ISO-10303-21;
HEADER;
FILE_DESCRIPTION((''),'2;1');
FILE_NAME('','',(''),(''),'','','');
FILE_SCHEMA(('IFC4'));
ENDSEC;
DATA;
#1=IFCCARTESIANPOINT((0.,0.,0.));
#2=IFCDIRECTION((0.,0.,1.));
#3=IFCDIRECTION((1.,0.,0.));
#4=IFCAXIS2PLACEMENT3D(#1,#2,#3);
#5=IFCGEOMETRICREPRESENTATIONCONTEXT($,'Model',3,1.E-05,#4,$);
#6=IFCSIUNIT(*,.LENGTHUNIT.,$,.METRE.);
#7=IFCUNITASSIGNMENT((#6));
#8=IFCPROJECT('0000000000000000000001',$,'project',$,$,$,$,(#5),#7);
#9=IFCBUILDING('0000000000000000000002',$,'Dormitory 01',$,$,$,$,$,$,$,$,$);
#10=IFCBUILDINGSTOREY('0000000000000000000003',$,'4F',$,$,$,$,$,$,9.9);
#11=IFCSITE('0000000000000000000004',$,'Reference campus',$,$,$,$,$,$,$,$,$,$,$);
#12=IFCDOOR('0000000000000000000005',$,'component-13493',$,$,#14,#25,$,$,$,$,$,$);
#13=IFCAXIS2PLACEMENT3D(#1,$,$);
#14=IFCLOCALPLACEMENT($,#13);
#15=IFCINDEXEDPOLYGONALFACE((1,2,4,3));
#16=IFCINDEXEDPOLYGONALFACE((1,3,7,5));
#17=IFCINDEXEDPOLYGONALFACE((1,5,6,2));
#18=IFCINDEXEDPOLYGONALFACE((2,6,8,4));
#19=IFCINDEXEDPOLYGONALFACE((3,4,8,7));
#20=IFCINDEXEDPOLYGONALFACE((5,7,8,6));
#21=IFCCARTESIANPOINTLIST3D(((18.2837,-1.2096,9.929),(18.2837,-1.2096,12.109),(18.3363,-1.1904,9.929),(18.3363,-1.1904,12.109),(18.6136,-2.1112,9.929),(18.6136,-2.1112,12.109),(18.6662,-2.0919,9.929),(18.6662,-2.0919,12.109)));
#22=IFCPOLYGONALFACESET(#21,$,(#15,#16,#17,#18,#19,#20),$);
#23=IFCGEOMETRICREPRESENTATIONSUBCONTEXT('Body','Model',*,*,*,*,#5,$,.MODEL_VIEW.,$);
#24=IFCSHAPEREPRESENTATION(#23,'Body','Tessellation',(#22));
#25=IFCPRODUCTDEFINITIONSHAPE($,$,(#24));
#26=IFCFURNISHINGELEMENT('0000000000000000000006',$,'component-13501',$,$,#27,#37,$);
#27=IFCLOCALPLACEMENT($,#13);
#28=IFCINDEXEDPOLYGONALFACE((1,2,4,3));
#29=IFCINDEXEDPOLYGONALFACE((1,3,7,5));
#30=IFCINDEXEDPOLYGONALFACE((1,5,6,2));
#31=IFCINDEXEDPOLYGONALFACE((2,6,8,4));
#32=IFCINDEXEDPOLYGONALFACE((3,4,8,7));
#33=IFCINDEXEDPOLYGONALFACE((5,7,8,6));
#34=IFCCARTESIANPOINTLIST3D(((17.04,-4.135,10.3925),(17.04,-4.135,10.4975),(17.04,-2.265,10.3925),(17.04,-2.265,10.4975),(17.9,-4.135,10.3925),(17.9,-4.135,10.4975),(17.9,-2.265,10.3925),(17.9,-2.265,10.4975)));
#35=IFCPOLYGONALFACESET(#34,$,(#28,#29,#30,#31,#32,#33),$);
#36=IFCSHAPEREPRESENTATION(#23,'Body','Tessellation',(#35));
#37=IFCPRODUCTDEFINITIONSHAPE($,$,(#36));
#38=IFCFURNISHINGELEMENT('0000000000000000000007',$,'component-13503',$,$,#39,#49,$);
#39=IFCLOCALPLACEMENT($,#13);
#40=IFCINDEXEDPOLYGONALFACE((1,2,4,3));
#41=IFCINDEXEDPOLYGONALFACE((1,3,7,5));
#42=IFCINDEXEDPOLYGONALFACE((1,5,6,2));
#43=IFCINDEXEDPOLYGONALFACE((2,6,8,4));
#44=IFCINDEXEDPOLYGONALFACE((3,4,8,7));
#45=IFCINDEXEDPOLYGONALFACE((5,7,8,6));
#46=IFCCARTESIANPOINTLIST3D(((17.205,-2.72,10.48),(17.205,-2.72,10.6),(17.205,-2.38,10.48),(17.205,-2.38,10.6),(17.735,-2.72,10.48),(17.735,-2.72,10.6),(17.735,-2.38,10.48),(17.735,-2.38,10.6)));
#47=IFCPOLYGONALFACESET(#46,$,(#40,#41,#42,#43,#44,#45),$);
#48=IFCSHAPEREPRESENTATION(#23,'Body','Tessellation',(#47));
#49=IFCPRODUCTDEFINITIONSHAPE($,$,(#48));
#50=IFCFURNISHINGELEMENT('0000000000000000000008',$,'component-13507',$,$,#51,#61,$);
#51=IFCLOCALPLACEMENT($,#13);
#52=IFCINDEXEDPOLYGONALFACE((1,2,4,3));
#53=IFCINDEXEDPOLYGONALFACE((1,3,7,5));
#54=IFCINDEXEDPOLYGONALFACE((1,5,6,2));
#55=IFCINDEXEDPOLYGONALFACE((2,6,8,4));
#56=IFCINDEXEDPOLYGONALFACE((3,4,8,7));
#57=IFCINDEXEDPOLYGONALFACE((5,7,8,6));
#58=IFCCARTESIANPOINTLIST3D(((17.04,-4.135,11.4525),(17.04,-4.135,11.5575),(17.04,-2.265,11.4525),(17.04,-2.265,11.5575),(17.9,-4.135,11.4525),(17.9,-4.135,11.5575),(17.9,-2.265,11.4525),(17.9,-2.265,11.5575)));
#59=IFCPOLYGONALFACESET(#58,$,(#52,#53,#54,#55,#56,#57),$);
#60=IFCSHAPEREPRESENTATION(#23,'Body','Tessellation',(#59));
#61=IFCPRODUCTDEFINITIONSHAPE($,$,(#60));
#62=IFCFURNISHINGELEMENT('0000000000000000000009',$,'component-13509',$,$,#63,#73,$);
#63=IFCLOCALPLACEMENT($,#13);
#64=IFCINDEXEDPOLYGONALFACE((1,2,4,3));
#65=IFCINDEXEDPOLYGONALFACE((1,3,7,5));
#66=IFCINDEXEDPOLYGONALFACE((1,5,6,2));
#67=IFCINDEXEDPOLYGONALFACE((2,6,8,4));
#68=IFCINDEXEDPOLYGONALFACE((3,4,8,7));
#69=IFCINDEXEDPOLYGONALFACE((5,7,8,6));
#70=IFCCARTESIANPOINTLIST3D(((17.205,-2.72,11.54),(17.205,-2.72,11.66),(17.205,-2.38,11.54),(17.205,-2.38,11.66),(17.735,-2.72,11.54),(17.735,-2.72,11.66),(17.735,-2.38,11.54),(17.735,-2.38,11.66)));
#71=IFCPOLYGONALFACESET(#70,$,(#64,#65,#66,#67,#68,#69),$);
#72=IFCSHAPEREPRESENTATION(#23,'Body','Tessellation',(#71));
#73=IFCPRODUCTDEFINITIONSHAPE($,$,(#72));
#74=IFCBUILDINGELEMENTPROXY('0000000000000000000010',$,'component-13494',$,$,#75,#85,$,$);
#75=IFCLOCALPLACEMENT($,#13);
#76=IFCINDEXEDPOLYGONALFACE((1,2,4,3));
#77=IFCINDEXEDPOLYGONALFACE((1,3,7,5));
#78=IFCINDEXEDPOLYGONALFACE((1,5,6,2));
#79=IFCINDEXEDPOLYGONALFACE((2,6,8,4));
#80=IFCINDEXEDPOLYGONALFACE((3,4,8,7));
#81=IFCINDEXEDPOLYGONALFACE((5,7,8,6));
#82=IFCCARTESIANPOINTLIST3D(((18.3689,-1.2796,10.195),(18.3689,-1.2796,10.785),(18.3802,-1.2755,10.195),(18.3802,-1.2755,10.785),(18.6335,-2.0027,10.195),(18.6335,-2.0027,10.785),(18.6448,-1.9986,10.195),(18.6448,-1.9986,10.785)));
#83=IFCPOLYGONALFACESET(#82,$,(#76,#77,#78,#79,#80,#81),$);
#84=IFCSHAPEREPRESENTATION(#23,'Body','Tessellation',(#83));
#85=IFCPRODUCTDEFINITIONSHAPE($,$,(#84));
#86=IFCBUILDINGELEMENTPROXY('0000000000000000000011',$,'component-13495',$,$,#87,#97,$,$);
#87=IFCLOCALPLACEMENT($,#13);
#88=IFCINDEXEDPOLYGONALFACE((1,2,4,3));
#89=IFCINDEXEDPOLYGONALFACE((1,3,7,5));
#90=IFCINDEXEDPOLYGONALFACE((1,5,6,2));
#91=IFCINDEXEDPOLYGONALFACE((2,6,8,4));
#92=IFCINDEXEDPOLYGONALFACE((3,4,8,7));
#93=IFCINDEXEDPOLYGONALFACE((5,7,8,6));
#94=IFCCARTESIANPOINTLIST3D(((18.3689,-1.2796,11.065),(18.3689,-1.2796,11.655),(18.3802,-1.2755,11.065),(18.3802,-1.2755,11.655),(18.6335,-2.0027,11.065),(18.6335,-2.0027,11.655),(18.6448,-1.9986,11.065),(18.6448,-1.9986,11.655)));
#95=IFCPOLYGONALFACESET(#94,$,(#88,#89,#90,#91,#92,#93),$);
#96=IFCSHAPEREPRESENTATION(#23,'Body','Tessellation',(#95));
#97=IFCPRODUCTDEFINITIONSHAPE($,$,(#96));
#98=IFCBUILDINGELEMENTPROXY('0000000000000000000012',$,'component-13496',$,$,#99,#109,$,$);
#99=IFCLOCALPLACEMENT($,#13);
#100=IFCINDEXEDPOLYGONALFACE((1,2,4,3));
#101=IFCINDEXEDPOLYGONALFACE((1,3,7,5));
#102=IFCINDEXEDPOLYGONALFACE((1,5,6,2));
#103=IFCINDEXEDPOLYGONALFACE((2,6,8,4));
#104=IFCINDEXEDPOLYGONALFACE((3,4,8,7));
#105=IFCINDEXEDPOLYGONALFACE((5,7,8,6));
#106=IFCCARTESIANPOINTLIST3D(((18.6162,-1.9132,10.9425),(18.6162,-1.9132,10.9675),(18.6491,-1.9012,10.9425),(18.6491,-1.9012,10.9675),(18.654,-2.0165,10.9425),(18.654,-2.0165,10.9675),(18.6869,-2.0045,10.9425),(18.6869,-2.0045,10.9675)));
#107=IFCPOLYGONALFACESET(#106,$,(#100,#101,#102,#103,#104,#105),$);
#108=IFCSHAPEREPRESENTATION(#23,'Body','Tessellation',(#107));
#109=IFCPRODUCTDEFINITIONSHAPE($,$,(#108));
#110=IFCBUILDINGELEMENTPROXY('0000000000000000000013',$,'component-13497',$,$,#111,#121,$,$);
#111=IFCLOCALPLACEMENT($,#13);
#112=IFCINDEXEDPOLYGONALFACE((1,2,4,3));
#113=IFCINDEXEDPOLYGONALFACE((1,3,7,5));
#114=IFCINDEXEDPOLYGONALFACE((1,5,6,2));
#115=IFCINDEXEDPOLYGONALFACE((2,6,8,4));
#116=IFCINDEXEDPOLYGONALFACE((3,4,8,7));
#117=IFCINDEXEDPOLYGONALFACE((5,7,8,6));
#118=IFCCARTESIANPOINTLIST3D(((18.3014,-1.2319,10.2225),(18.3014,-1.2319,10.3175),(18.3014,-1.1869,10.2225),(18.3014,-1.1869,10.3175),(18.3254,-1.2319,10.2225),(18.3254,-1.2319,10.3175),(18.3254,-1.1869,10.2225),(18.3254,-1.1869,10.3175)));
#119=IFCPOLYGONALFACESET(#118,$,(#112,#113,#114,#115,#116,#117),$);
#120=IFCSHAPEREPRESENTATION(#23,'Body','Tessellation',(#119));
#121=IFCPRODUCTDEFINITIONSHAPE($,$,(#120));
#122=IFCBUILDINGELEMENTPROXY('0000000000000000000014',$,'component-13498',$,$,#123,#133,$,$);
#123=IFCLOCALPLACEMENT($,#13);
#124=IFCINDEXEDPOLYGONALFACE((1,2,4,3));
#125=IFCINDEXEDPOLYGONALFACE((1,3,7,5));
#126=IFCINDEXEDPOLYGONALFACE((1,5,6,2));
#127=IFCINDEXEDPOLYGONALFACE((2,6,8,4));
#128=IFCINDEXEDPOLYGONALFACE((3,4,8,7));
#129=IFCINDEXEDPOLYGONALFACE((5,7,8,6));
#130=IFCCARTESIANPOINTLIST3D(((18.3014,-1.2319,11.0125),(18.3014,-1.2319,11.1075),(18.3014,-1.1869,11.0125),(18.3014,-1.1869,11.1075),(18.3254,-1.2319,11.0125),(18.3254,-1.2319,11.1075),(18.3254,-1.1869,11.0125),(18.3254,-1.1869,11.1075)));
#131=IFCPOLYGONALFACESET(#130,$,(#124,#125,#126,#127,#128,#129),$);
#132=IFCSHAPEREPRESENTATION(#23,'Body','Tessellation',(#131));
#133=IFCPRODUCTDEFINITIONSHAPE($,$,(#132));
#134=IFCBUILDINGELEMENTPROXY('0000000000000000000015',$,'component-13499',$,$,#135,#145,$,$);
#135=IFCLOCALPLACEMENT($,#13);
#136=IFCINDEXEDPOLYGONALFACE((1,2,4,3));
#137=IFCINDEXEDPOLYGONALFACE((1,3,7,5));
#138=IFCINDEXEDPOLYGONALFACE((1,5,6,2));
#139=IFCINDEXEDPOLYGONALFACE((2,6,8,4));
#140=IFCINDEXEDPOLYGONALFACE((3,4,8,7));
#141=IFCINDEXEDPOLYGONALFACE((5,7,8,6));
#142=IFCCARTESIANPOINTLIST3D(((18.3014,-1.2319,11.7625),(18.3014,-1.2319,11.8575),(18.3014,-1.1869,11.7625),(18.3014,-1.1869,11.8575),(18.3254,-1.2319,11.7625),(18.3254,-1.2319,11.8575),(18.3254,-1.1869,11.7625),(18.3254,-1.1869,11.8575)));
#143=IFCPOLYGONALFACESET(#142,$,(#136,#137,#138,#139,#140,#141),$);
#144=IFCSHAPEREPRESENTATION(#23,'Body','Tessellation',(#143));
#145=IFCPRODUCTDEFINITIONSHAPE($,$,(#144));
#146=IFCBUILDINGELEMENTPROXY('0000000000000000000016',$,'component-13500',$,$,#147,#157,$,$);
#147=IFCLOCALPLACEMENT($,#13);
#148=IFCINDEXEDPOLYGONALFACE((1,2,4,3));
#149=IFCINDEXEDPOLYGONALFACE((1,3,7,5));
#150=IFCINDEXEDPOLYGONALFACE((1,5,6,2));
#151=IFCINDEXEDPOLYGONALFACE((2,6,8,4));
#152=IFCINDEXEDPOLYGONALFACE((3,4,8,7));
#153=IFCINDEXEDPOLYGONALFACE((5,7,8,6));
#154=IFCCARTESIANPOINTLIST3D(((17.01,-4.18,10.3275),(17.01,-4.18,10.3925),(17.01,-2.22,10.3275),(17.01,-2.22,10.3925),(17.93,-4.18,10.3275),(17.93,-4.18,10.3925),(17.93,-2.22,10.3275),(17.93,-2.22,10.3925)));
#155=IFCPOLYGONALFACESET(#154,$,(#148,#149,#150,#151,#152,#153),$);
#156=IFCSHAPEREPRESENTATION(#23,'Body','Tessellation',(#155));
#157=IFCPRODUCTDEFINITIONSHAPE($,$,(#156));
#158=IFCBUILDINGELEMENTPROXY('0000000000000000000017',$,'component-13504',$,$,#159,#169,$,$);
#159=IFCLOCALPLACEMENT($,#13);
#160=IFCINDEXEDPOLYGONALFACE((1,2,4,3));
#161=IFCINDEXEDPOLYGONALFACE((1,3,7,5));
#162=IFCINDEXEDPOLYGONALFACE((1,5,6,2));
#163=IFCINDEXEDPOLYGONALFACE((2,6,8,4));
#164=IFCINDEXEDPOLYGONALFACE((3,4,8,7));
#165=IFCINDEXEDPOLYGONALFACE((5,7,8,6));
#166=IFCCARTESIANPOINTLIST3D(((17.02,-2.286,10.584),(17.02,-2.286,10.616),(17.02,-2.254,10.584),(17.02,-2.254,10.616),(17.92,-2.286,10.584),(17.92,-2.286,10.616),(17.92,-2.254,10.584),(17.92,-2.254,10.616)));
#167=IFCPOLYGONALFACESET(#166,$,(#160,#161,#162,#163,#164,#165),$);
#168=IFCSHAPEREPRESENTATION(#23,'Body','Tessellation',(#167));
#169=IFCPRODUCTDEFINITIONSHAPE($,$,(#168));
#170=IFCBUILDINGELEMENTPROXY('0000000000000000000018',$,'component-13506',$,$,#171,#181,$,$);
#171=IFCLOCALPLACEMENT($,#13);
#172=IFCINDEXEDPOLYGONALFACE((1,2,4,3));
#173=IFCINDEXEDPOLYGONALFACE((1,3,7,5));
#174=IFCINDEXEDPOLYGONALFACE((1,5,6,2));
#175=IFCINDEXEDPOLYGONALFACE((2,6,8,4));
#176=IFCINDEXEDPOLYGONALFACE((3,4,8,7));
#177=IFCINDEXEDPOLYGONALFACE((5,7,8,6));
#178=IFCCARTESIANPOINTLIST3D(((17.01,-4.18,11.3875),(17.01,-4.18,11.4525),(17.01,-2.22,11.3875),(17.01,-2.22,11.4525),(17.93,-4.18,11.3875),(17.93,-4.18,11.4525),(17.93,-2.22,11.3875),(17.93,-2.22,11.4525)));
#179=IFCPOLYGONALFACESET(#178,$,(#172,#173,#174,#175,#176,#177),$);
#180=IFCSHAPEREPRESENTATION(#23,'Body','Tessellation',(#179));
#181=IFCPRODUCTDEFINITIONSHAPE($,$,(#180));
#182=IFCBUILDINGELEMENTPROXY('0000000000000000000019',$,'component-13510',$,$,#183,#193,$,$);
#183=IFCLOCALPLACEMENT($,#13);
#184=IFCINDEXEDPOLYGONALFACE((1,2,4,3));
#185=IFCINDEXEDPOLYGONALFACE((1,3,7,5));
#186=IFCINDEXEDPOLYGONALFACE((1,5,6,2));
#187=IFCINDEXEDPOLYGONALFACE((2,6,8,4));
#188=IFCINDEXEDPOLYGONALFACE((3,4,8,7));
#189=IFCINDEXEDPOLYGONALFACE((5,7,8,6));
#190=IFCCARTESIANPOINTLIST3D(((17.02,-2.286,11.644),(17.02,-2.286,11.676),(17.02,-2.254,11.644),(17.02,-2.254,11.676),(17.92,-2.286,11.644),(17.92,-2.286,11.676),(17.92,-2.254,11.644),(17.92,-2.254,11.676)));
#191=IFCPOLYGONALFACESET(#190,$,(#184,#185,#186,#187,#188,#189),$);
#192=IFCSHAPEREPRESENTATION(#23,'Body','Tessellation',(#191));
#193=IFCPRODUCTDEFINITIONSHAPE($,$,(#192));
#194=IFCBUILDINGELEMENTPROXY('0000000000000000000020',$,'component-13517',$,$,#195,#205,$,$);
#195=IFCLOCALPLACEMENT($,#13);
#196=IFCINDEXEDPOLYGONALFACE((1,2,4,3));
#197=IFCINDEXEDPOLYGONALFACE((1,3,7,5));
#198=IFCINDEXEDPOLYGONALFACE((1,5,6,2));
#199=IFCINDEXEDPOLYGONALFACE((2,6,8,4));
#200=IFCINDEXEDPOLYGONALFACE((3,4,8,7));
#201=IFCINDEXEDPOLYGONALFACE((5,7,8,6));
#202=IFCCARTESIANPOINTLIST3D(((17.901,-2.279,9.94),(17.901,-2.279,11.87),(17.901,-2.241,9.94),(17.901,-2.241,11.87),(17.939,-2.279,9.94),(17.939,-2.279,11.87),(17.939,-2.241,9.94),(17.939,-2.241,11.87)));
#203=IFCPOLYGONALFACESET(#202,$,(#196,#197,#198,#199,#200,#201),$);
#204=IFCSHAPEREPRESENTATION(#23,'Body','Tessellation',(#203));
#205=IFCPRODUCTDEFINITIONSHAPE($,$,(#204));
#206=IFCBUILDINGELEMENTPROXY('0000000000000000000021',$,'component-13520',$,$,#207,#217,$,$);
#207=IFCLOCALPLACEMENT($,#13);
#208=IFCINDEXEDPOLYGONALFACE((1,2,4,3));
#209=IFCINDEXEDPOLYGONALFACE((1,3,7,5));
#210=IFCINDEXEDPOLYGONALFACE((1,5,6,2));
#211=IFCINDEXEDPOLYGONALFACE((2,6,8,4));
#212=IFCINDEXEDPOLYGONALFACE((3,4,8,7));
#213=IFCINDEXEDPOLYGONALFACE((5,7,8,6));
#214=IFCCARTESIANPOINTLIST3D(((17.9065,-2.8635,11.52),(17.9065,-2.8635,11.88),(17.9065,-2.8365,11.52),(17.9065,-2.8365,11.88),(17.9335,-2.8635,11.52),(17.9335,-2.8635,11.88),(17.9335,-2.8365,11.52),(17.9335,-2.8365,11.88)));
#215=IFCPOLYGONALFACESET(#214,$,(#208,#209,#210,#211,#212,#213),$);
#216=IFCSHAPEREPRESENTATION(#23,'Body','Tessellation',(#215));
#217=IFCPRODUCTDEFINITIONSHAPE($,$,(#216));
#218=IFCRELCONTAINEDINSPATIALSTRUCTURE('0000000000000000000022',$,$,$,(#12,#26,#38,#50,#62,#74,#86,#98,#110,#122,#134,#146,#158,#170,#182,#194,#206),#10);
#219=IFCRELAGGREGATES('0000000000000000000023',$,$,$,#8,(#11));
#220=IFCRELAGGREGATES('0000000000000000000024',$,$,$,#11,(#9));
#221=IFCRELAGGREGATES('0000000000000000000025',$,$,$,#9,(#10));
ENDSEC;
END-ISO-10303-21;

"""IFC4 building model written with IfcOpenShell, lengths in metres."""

from ifc_helpers import new_model, si_unit, frame, origin, origin_with_axes, origin_2d, place, context, subcontext, project, spatial, rectangle, extrude, element, save


model = new_model("IFC4")

# Units and contexts
model_context = context("Model", 3, precision=1e-05, world=origin_with_axes())
body_context = subcontext(model_context, "Body", "Model", "MODEL_VIEW")
ifc_project = project(units=[si_unit("LENGTHUNIT", "METRE")], contexts=[model_context])

# Site, building, storey
site = spatial("IfcSite", under=ifc_project, Name="Reference campus")
building = spatial("IfcBuilding", under=site, Name="Dormitory 01")
storey = spatial("IfcBuildingStorey", under=building, Name="4F", Elevation=9.9)

# Door
door_placement = place(None, frame((18.4749, -1.6508, 9.929), z_axis=(0.0, 0.0, 1.0), x_axis=(0.343646, -0.939099, 0.0)))
element("IfcDoor", 1, at=door_placement, inside=storey, Name="component-13493", context=body_context, shape_type="SweptSolid", body=[
    extrude(rectangle(XDim=0.96, YDim=0.056, at=origin_2d()), origin(), (0.0, 0.0, 1.0), 2.18),
])

# Furnishing elements
furnishing_1_placement = place(None, frame((17.47, -3.2, 10.3925), z_axis=(0.0, 0.0, 1.0), x_axis=(1.0, 0.0, 0.0)))
element("IfcFurnishingElement", 2, at=furnishing_1_placement, inside=storey, Name="component-13501", context=body_context, shape_type="SweptSolid", body=[
    extrude(rectangle(XDim=0.86, YDim=1.87, at=origin_2d()), origin(), (0.0, 0.0, 1.0), 0.105),
])
furnishing_2_placement = place(None, frame((17.47, -2.55, 10.48), z_axis=(0.0, 0.0, 1.0), x_axis=(1.0, 0.0, 0.0)))
element("IfcFurnishingElement", 3, at=furnishing_2_placement, inside=storey, Name="component-13503", context=body_context, shape_type="SweptSolid", body=[
    extrude(rectangle(XDim=0.53, YDim=0.34, at=origin_2d()), origin(), (0.0, 0.0, 1.0), 0.12),
])
furnishing_3_placement = place(None, frame((17.47, -3.2, 11.4525), z_axis=(0.0, 0.0, 1.0), x_axis=(1.0, 0.0, 0.0)))
element("IfcFurnishingElement", 4, at=furnishing_3_placement, inside=storey, Name="component-13507", context=body_context, shape_type="SweptSolid", body=[
    extrude(rectangle(XDim=0.86, YDim=1.87, at=origin_2d()), origin(), (0.0, 0.0, 1.0), 0.105),
])
furnishing_4_placement = place(None, frame((17.47, -2.55, 11.54), z_axis=(0.0, 0.0, 1.0), x_axis=(1.0, 0.0, 0.0)))
element("IfcFurnishingElement", 5, at=furnishing_4_placement, inside=storey, Name="component-13509", context=body_context, shape_type="SweptSolid", body=[
    extrude(rectangle(XDim=0.53, YDim=0.34, at=origin_2d()), origin(), (0.0, 0.0, 1.0), 0.12),
])

# Building element proxies
for number, where, z_axis, x_axis, name in (
    (6, (18.5069, -1.6391, 10.195), (0.0, 0.0, 1.0), (0.343646, -0.939099, 0.0), "component-13494"),
    (7, (18.5069, -1.6391, 11.065), (0.0, 0.0, 1.0), (0.343646, -0.939099, 0.0), "component-13495"),
):
    element("IfcBuildingElementProxy", number, at=place(None, frame(where, z_axis=z_axis, x_axis=x_axis)), inside=storey, Name=name, context=body_context, shape_type="SweptSolid", body=[
        extrude(rectangle(XDim=0.77, YDim=0.012, at=origin_2d()), origin(), (0.0, 0.0, 1.0), 0.59),
    ])
proxy_1_placement = place(None, frame((18.6516, -1.9588, 10.9425), z_axis=(0.0, 0.0, 1.0), x_axis=(0.343646, -0.939099, 0.0)))
element("IfcBuildingElementProxy", 8, at=proxy_1_placement, inside=storey, Name="component-13496", context=body_context, shape_type="SweptSolid", body=[
    extrude(rectangle(XDim=0.11, YDim=0.035, at=origin_2d()), origin(), (0.0, 0.0, 1.0), 0.025),
])
for number, where, z_axis, x_axis, name in (
    (9, (18.3134, -1.2094, 10.2225), (0.0, 0.0, 1.0), (1.0, 0.0, 0.0), "component-13497"),
    (10, (18.3134, -1.2094, 11.0125), (0.0, 0.0, 1.0), (1.0, 0.0, 0.0), "component-13498"),
    (11, (18.3134, -1.2094, 11.7625), (0.0, 0.0, 1.0), (1.0, 0.0, 0.0), "component-13499"),
):
    element("IfcBuildingElementProxy", number, at=place(None, frame(where, z_axis=z_axis, x_axis=x_axis)), inside=storey, Name=name, context=body_context, shape_type="SweptSolid", body=[
        extrude(rectangle(XDim=0.024, YDim=0.045, at=origin_2d()), origin(), (0.0, 0.0, 1.0), 0.095),
    ])
proxy_2_placement = place(None, frame((17.47, -3.2, 10.3275), z_axis=(0.0, 0.0, 1.0), x_axis=(1.0, 0.0, 0.0)))
element("IfcBuildingElementProxy", 12, at=proxy_2_placement, inside=storey, Name="component-13500", context=body_context, shape_type="SweptSolid", body=[
    extrude(rectangle(XDim=0.92, YDim=1.96, at=origin_2d()), origin(), (0.0, 0.0, 1.0), 0.065),
])
proxy_3_placement = place(None, frame((17.47, -2.27, 10.584), z_axis=(0.0, 0.0, 1.0), x_axis=(1.0, 0.0, 0.0)))
element("IfcBuildingElementProxy", 13, at=proxy_3_placement, inside=storey, Name="component-13504", context=body_context, shape_type="SweptSolid", body=[
    extrude(rectangle(XDim=0.9, YDim=0.032, at=origin_2d()), origin(), (0.0, 0.0, 1.0), 0.032),
])
proxy_4_placement = place(None, frame((17.47, -3.2, 11.3875), z_axis=(0.0, 0.0, 1.0), x_axis=(1.0, 0.0, 0.0)))
element("IfcBuildingElementProxy", 14, at=proxy_4_placement, inside=storey, Name="component-13506", context=body_context, shape_type="SweptSolid", body=[
    extrude(rectangle(XDim=0.92, YDim=1.96, at=origin_2d()), origin(), (0.0, 0.0, 1.0), 0.065),
])
proxy_5_placement = place(None, frame((17.47, -2.27, 11.644), z_axis=(0.0, 0.0, 1.0), x_axis=(1.0, 0.0, 0.0)))
element("IfcBuildingElementProxy", 15, at=proxy_5_placement, inside=storey, Name="component-13510", context=body_context, shape_type="SweptSolid", body=[
    extrude(rectangle(XDim=0.9, YDim=0.032, at=origin_2d()), origin(), (0.0, 0.0, 1.0), 0.032),
])
proxy_6_placement = place(None, frame((17.92, -2.26, 9.94), z_axis=(0.0, 0.0, 1.0), x_axis=(1.0, 0.0, 0.0)))
element("IfcBuildingElementProxy", 16, at=proxy_6_placement, inside=storey, Name="component-13517", context=body_context, shape_type="SweptSolid", body=[
    extrude(rectangle(XDim=0.038, YDim=0.038, at=origin_2d()), origin(), (0.0, 0.0, 1.0), 1.93),
])
proxy_7_placement = place(None, frame((17.92, -2.85, 11.52), z_axis=(0.0, 0.0, 1.0), x_axis=(1.0, 0.0, 0.0)))
element("IfcBuildingElementProxy", 17, at=proxy_7_placement, inside=storey, Name="component-13520", context=body_context, shape_type="SweptSolid", body=[
    extrude(rectangle(XDim=0.027, YDim=0.027, at=origin_2d()), origin(), (0.0, 0.0, 1.0), 0.36),
])

save(model, "model.ifc")
